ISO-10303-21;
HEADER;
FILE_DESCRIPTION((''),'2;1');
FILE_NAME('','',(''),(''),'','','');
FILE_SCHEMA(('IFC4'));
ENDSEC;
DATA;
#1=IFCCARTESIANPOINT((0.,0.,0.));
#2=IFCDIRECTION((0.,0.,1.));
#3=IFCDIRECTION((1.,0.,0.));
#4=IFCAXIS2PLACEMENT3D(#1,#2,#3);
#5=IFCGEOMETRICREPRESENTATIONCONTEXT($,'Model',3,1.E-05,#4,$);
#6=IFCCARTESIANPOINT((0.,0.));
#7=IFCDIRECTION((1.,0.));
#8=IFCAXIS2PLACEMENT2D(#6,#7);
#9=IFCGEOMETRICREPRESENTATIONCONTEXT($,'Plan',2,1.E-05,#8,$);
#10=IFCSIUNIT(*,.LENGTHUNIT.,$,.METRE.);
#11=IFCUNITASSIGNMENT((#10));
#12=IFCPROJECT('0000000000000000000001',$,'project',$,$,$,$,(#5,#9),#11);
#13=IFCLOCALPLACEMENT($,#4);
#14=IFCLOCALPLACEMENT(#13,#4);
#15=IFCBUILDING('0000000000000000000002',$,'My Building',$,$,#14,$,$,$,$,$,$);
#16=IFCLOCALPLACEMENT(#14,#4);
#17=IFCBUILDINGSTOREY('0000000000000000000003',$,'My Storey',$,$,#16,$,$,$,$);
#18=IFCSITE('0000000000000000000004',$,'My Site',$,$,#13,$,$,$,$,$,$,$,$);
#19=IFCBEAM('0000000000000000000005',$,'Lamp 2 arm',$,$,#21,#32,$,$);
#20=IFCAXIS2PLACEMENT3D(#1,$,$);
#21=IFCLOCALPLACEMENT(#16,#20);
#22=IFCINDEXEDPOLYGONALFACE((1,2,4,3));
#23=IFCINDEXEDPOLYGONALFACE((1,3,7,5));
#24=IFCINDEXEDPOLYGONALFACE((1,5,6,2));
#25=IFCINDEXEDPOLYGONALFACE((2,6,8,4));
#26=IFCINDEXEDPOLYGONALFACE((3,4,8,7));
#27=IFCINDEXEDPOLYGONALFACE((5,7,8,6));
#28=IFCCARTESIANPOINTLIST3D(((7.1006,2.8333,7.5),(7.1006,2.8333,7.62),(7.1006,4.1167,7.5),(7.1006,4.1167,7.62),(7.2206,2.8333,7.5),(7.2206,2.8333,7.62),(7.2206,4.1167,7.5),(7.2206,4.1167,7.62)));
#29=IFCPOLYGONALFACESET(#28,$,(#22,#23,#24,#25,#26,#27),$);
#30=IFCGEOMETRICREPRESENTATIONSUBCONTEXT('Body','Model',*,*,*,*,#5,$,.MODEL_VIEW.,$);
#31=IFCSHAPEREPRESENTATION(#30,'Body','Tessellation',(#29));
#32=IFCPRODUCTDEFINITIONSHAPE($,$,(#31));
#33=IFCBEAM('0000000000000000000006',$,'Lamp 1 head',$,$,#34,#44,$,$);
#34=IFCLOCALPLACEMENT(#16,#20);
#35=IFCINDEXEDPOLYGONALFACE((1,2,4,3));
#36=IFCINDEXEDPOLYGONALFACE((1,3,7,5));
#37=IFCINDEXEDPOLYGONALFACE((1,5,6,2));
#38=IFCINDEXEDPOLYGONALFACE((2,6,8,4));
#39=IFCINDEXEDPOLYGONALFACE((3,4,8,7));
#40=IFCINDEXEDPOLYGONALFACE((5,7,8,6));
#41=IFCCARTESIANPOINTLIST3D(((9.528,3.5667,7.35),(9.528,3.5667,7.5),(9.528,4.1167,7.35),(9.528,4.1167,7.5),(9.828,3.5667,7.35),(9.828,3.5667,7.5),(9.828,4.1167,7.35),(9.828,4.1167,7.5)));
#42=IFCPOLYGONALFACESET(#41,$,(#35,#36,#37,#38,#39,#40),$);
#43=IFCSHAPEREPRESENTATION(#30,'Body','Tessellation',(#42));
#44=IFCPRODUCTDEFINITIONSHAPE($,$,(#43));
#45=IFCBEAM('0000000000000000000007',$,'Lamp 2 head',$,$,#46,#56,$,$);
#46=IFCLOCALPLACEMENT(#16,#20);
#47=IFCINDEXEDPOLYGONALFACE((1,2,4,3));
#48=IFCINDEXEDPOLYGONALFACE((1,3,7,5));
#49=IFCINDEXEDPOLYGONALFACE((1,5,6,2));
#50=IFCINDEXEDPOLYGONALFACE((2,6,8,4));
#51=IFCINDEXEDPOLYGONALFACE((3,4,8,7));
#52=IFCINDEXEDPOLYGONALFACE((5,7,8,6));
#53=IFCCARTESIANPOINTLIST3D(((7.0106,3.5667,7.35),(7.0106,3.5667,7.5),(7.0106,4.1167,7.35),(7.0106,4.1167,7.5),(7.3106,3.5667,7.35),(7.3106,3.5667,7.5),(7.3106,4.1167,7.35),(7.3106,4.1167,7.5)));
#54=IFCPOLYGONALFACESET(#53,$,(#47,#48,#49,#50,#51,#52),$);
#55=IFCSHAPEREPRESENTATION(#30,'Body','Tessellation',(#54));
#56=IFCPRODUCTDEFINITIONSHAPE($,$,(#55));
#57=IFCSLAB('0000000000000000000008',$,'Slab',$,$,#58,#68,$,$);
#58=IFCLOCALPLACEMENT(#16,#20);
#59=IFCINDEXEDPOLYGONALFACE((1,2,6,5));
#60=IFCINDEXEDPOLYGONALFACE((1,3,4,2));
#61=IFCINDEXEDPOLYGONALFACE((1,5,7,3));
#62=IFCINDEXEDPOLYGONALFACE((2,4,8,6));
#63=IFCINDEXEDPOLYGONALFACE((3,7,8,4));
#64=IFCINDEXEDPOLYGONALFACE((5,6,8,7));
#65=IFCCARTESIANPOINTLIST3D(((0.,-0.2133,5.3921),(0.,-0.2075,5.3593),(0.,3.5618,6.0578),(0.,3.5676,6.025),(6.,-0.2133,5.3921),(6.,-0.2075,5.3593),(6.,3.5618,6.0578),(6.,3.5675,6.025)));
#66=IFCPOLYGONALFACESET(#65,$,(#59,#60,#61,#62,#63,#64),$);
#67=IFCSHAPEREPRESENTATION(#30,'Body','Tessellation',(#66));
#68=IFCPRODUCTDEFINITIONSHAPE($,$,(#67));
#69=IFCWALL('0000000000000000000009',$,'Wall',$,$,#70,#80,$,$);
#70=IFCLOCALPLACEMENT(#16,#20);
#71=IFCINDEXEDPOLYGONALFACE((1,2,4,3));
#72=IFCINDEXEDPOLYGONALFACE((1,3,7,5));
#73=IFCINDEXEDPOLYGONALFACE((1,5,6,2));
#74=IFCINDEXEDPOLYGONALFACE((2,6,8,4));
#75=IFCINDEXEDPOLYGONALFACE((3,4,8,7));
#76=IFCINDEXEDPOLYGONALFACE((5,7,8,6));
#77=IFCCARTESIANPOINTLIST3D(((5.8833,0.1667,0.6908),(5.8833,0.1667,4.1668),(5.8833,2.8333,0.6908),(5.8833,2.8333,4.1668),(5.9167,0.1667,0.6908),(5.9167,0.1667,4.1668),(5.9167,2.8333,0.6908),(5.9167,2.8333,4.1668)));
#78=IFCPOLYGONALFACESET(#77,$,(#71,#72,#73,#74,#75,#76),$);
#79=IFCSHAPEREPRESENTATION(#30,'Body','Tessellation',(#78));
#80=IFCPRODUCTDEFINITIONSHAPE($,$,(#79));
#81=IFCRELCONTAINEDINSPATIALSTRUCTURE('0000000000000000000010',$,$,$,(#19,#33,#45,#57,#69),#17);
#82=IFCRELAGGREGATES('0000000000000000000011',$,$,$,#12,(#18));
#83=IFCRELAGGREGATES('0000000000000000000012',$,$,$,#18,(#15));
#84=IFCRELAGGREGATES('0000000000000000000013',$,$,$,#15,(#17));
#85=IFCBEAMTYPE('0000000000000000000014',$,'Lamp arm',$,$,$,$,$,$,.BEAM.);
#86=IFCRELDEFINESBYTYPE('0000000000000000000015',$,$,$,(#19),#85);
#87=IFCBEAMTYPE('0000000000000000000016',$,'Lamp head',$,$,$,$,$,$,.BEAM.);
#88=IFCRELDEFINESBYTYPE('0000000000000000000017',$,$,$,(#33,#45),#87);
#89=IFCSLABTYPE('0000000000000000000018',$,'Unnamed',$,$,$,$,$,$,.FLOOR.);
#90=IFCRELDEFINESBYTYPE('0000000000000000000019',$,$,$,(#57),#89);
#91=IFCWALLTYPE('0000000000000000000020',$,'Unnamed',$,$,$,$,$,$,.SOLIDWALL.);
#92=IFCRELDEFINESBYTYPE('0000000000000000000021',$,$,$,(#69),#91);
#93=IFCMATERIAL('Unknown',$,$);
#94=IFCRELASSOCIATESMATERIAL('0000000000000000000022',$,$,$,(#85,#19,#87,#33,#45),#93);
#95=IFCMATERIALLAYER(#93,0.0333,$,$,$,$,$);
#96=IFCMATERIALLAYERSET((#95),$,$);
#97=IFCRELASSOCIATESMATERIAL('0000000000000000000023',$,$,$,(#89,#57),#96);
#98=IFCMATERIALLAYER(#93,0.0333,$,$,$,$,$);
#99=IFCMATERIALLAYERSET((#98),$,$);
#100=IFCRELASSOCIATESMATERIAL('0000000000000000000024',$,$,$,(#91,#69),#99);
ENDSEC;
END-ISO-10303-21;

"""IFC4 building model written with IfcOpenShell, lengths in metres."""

from ifc_helpers import new_model, si_unit, frame, origin_with_axes, origin_2d_with_axis, place, context, subcontext, project, spatial, line, indexed_curve, rectangle, outline, extrude, material, layer, layer_set, layer_usage, material_profile, profile_set, profile_usage, type_object, element, save


model = new_model("IFC4")

# Units and contexts
model_context = context("Model", 3, precision=1e-05, world=origin_with_axes())
plan_context = context("Plan", 2, precision=1e-05, world=origin_2d_with_axis())
body_context = subcontext(model_context, "Body", "Model", "MODEL_VIEW")
ifc_project = project(units=[si_unit("LENGTHUNIT", "METRE")], contexts=[model_context, plan_context])

# Site, building, storey
site_placement = place(None, origin_with_axes())
site = spatial("IfcSite", under=ifc_project, at=site_placement, Name="My Site")
building_placement = place(site_placement, origin_with_axes())
building = spatial("IfcBuilding", under=site, at=building_placement, Name="My Building")
storey_placement = place(building_placement, origin_with_axes())
storey = spatial("IfcBuildingStorey", under=building, at=storey_placement, Name="My Storey")

# Shared definitions
ifc_material = material(Name="Unknown")

# Beams
ifc_material_profile_1 = material_profile(ifc_material, rectangle(XDim=0.12, YDim=0.12))
ifc_profile_set_1 = profile_set([ifc_material_profile_1])
beam_type_1 = type_object("IfcBeamType", Name="Lamp arm", PredefinedType="BEAM", material=ifc_profile_set_1)
ifc_profile_usage_1 = profile_usage(ifc_profile_set_1, cardinal=5)
beam_1_placement = place(storey_placement, frame((7.1606, 2.8333, 7.56), z_axis=(0.0, 1.0, 0.0), x_axis=(1.0, 0.0, 0.0)))
element("IfcBeam", 1, at=beam_1_placement, inside=storey, type_object=beam_type_1, material=ifc_profile_usage_1, Name="Lamp 2 arm", context=body_context, shape_type="SweptSolid", body=[
    extrude(rectangle(XDim=0.12, YDim=0.12), origin_with_axes(), (0.0, 0.0, 1.0), 1.2833),
])
ifc_material_profile_2 = material_profile(ifc_material, rectangle(XDim=0.3, YDim=0.15))
ifc_profile_set_2 = profile_set([ifc_material_profile_2])
ifc_profile_usage_2 = profile_usage(ifc_profile_set_2, cardinal=5)
beam_type_2 = type_object("IfcBeamType", Name="Lamp head", PredefinedType="BEAM", material=ifc_profile_set_2)
beam_2_placement = place(storey_placement, frame((9.678, 3.5667, 7.425), z_axis=(0.0, 1.0, 0.0), x_axis=(1.0, 0.0, 0.0)))
element("IfcBeam", 2, at=beam_2_placement, inside=storey, type_object=beam_type_2, material=ifc_profile_usage_2, Name="Lamp 1 head", context=body_context, shape_type="SweptSolid", body=[
    extrude(rectangle(XDim=0.3, YDim=0.15), origin_with_axes(), (0.0, 0.0, 1.0), 0.55),
])
ifc_profile_usage_3 = profile_usage(ifc_profile_set_2, cardinal=5)
beam_3_placement = place(storey_placement, frame((7.1606, 3.5667, 7.425), z_axis=(0.0, 1.0, 0.0), x_axis=(1.0, 0.0, 0.0)))
element("IfcBeam", 3, at=beam_3_placement, inside=storey, type_object=beam_type_2, material=ifc_profile_usage_3, Name="Lamp 2 head", context=body_context, shape_type="SweptSolid", body=[
    extrude(rectangle(XDim=0.3, YDim=0.15), origin_with_axes(), (0.0, 0.0, 1.0), 0.55),
])

# Slab
ifc_layer_1 = layer(ifc_material, 0.0333)
ifc_layer_set_1 = layer_set([ifc_layer_1])
ifc_layer_usage_1 = layer_usage(ifc_layer_set_1, "AXIS3", "POSITIVE", -0.0333)
slab_type = type_object("IfcSlabType", Name="Unnamed", PredefinedType="FLOOR", material=ifc_layer_set_1)
slab_placement = place(storey_placement, frame((6.0, -0.2133, 5.3921), z_axis=(0.0, -0.173648, 0.984808), x_axis=(0.0, 0.984808, 0.173648)))
element("IfcSlab", 4, at=slab_placement, inside=storey, type_object=slab_type, material=ifc_layer_usage_1, Name="Slab", context=body_context, shape_type="SweptSolid", body=[
    extrude(outline(indexed_curve([(0.0, 0.0), (0.0, 6.0), (3.8333, 6.0), (3.8333, 0.0), (0.0, 0.0)])), frame((0.0, 0.0, -0.0333), z_axis=(0.0, 0.0, 1.0), x_axis=(1.0, 0.0, 0.0)), (0.0, 0.0, 1.0), 0.0333),
])

# Wall
ifc_layer_2 = layer(ifc_material, 0.0333)
ifc_layer_set_2 = layer_set([ifc_layer_2])
ifc_layer_usage_2 = layer_usage(ifc_layer_set_2, "AXIS2", "POSITIVE", 0.0)
wall_type = type_object("IfcWallType", Name="Unnamed", PredefinedType="SOLIDWALL", material=ifc_layer_set_2)
wall_placement = place(storey_placement, frame((5.9167, 0.1667, 0.6908), z_axis=(0.0, 0.0, 1.0), x_axis=(-0.000003, 1.0, 0.0)))
element("IfcWall", 5, at=wall_placement, inside=storey, type_object=wall_type, material=ifc_layer_usage_2, Name="Wall", context=body_context, shape_type="SweptSolid", body=[
    extrude(outline(indexed_curve([(0.0, 0.0), (0.0, 0.0333), (2.6667, 0.0333), (2.6667, 0.0)], segments=[line(1, 2, 3, 4, 1)])), origin_with_axes(), (0.0, 0.0, 1.0), 3.476),
])

save(model, "model.ifc")
